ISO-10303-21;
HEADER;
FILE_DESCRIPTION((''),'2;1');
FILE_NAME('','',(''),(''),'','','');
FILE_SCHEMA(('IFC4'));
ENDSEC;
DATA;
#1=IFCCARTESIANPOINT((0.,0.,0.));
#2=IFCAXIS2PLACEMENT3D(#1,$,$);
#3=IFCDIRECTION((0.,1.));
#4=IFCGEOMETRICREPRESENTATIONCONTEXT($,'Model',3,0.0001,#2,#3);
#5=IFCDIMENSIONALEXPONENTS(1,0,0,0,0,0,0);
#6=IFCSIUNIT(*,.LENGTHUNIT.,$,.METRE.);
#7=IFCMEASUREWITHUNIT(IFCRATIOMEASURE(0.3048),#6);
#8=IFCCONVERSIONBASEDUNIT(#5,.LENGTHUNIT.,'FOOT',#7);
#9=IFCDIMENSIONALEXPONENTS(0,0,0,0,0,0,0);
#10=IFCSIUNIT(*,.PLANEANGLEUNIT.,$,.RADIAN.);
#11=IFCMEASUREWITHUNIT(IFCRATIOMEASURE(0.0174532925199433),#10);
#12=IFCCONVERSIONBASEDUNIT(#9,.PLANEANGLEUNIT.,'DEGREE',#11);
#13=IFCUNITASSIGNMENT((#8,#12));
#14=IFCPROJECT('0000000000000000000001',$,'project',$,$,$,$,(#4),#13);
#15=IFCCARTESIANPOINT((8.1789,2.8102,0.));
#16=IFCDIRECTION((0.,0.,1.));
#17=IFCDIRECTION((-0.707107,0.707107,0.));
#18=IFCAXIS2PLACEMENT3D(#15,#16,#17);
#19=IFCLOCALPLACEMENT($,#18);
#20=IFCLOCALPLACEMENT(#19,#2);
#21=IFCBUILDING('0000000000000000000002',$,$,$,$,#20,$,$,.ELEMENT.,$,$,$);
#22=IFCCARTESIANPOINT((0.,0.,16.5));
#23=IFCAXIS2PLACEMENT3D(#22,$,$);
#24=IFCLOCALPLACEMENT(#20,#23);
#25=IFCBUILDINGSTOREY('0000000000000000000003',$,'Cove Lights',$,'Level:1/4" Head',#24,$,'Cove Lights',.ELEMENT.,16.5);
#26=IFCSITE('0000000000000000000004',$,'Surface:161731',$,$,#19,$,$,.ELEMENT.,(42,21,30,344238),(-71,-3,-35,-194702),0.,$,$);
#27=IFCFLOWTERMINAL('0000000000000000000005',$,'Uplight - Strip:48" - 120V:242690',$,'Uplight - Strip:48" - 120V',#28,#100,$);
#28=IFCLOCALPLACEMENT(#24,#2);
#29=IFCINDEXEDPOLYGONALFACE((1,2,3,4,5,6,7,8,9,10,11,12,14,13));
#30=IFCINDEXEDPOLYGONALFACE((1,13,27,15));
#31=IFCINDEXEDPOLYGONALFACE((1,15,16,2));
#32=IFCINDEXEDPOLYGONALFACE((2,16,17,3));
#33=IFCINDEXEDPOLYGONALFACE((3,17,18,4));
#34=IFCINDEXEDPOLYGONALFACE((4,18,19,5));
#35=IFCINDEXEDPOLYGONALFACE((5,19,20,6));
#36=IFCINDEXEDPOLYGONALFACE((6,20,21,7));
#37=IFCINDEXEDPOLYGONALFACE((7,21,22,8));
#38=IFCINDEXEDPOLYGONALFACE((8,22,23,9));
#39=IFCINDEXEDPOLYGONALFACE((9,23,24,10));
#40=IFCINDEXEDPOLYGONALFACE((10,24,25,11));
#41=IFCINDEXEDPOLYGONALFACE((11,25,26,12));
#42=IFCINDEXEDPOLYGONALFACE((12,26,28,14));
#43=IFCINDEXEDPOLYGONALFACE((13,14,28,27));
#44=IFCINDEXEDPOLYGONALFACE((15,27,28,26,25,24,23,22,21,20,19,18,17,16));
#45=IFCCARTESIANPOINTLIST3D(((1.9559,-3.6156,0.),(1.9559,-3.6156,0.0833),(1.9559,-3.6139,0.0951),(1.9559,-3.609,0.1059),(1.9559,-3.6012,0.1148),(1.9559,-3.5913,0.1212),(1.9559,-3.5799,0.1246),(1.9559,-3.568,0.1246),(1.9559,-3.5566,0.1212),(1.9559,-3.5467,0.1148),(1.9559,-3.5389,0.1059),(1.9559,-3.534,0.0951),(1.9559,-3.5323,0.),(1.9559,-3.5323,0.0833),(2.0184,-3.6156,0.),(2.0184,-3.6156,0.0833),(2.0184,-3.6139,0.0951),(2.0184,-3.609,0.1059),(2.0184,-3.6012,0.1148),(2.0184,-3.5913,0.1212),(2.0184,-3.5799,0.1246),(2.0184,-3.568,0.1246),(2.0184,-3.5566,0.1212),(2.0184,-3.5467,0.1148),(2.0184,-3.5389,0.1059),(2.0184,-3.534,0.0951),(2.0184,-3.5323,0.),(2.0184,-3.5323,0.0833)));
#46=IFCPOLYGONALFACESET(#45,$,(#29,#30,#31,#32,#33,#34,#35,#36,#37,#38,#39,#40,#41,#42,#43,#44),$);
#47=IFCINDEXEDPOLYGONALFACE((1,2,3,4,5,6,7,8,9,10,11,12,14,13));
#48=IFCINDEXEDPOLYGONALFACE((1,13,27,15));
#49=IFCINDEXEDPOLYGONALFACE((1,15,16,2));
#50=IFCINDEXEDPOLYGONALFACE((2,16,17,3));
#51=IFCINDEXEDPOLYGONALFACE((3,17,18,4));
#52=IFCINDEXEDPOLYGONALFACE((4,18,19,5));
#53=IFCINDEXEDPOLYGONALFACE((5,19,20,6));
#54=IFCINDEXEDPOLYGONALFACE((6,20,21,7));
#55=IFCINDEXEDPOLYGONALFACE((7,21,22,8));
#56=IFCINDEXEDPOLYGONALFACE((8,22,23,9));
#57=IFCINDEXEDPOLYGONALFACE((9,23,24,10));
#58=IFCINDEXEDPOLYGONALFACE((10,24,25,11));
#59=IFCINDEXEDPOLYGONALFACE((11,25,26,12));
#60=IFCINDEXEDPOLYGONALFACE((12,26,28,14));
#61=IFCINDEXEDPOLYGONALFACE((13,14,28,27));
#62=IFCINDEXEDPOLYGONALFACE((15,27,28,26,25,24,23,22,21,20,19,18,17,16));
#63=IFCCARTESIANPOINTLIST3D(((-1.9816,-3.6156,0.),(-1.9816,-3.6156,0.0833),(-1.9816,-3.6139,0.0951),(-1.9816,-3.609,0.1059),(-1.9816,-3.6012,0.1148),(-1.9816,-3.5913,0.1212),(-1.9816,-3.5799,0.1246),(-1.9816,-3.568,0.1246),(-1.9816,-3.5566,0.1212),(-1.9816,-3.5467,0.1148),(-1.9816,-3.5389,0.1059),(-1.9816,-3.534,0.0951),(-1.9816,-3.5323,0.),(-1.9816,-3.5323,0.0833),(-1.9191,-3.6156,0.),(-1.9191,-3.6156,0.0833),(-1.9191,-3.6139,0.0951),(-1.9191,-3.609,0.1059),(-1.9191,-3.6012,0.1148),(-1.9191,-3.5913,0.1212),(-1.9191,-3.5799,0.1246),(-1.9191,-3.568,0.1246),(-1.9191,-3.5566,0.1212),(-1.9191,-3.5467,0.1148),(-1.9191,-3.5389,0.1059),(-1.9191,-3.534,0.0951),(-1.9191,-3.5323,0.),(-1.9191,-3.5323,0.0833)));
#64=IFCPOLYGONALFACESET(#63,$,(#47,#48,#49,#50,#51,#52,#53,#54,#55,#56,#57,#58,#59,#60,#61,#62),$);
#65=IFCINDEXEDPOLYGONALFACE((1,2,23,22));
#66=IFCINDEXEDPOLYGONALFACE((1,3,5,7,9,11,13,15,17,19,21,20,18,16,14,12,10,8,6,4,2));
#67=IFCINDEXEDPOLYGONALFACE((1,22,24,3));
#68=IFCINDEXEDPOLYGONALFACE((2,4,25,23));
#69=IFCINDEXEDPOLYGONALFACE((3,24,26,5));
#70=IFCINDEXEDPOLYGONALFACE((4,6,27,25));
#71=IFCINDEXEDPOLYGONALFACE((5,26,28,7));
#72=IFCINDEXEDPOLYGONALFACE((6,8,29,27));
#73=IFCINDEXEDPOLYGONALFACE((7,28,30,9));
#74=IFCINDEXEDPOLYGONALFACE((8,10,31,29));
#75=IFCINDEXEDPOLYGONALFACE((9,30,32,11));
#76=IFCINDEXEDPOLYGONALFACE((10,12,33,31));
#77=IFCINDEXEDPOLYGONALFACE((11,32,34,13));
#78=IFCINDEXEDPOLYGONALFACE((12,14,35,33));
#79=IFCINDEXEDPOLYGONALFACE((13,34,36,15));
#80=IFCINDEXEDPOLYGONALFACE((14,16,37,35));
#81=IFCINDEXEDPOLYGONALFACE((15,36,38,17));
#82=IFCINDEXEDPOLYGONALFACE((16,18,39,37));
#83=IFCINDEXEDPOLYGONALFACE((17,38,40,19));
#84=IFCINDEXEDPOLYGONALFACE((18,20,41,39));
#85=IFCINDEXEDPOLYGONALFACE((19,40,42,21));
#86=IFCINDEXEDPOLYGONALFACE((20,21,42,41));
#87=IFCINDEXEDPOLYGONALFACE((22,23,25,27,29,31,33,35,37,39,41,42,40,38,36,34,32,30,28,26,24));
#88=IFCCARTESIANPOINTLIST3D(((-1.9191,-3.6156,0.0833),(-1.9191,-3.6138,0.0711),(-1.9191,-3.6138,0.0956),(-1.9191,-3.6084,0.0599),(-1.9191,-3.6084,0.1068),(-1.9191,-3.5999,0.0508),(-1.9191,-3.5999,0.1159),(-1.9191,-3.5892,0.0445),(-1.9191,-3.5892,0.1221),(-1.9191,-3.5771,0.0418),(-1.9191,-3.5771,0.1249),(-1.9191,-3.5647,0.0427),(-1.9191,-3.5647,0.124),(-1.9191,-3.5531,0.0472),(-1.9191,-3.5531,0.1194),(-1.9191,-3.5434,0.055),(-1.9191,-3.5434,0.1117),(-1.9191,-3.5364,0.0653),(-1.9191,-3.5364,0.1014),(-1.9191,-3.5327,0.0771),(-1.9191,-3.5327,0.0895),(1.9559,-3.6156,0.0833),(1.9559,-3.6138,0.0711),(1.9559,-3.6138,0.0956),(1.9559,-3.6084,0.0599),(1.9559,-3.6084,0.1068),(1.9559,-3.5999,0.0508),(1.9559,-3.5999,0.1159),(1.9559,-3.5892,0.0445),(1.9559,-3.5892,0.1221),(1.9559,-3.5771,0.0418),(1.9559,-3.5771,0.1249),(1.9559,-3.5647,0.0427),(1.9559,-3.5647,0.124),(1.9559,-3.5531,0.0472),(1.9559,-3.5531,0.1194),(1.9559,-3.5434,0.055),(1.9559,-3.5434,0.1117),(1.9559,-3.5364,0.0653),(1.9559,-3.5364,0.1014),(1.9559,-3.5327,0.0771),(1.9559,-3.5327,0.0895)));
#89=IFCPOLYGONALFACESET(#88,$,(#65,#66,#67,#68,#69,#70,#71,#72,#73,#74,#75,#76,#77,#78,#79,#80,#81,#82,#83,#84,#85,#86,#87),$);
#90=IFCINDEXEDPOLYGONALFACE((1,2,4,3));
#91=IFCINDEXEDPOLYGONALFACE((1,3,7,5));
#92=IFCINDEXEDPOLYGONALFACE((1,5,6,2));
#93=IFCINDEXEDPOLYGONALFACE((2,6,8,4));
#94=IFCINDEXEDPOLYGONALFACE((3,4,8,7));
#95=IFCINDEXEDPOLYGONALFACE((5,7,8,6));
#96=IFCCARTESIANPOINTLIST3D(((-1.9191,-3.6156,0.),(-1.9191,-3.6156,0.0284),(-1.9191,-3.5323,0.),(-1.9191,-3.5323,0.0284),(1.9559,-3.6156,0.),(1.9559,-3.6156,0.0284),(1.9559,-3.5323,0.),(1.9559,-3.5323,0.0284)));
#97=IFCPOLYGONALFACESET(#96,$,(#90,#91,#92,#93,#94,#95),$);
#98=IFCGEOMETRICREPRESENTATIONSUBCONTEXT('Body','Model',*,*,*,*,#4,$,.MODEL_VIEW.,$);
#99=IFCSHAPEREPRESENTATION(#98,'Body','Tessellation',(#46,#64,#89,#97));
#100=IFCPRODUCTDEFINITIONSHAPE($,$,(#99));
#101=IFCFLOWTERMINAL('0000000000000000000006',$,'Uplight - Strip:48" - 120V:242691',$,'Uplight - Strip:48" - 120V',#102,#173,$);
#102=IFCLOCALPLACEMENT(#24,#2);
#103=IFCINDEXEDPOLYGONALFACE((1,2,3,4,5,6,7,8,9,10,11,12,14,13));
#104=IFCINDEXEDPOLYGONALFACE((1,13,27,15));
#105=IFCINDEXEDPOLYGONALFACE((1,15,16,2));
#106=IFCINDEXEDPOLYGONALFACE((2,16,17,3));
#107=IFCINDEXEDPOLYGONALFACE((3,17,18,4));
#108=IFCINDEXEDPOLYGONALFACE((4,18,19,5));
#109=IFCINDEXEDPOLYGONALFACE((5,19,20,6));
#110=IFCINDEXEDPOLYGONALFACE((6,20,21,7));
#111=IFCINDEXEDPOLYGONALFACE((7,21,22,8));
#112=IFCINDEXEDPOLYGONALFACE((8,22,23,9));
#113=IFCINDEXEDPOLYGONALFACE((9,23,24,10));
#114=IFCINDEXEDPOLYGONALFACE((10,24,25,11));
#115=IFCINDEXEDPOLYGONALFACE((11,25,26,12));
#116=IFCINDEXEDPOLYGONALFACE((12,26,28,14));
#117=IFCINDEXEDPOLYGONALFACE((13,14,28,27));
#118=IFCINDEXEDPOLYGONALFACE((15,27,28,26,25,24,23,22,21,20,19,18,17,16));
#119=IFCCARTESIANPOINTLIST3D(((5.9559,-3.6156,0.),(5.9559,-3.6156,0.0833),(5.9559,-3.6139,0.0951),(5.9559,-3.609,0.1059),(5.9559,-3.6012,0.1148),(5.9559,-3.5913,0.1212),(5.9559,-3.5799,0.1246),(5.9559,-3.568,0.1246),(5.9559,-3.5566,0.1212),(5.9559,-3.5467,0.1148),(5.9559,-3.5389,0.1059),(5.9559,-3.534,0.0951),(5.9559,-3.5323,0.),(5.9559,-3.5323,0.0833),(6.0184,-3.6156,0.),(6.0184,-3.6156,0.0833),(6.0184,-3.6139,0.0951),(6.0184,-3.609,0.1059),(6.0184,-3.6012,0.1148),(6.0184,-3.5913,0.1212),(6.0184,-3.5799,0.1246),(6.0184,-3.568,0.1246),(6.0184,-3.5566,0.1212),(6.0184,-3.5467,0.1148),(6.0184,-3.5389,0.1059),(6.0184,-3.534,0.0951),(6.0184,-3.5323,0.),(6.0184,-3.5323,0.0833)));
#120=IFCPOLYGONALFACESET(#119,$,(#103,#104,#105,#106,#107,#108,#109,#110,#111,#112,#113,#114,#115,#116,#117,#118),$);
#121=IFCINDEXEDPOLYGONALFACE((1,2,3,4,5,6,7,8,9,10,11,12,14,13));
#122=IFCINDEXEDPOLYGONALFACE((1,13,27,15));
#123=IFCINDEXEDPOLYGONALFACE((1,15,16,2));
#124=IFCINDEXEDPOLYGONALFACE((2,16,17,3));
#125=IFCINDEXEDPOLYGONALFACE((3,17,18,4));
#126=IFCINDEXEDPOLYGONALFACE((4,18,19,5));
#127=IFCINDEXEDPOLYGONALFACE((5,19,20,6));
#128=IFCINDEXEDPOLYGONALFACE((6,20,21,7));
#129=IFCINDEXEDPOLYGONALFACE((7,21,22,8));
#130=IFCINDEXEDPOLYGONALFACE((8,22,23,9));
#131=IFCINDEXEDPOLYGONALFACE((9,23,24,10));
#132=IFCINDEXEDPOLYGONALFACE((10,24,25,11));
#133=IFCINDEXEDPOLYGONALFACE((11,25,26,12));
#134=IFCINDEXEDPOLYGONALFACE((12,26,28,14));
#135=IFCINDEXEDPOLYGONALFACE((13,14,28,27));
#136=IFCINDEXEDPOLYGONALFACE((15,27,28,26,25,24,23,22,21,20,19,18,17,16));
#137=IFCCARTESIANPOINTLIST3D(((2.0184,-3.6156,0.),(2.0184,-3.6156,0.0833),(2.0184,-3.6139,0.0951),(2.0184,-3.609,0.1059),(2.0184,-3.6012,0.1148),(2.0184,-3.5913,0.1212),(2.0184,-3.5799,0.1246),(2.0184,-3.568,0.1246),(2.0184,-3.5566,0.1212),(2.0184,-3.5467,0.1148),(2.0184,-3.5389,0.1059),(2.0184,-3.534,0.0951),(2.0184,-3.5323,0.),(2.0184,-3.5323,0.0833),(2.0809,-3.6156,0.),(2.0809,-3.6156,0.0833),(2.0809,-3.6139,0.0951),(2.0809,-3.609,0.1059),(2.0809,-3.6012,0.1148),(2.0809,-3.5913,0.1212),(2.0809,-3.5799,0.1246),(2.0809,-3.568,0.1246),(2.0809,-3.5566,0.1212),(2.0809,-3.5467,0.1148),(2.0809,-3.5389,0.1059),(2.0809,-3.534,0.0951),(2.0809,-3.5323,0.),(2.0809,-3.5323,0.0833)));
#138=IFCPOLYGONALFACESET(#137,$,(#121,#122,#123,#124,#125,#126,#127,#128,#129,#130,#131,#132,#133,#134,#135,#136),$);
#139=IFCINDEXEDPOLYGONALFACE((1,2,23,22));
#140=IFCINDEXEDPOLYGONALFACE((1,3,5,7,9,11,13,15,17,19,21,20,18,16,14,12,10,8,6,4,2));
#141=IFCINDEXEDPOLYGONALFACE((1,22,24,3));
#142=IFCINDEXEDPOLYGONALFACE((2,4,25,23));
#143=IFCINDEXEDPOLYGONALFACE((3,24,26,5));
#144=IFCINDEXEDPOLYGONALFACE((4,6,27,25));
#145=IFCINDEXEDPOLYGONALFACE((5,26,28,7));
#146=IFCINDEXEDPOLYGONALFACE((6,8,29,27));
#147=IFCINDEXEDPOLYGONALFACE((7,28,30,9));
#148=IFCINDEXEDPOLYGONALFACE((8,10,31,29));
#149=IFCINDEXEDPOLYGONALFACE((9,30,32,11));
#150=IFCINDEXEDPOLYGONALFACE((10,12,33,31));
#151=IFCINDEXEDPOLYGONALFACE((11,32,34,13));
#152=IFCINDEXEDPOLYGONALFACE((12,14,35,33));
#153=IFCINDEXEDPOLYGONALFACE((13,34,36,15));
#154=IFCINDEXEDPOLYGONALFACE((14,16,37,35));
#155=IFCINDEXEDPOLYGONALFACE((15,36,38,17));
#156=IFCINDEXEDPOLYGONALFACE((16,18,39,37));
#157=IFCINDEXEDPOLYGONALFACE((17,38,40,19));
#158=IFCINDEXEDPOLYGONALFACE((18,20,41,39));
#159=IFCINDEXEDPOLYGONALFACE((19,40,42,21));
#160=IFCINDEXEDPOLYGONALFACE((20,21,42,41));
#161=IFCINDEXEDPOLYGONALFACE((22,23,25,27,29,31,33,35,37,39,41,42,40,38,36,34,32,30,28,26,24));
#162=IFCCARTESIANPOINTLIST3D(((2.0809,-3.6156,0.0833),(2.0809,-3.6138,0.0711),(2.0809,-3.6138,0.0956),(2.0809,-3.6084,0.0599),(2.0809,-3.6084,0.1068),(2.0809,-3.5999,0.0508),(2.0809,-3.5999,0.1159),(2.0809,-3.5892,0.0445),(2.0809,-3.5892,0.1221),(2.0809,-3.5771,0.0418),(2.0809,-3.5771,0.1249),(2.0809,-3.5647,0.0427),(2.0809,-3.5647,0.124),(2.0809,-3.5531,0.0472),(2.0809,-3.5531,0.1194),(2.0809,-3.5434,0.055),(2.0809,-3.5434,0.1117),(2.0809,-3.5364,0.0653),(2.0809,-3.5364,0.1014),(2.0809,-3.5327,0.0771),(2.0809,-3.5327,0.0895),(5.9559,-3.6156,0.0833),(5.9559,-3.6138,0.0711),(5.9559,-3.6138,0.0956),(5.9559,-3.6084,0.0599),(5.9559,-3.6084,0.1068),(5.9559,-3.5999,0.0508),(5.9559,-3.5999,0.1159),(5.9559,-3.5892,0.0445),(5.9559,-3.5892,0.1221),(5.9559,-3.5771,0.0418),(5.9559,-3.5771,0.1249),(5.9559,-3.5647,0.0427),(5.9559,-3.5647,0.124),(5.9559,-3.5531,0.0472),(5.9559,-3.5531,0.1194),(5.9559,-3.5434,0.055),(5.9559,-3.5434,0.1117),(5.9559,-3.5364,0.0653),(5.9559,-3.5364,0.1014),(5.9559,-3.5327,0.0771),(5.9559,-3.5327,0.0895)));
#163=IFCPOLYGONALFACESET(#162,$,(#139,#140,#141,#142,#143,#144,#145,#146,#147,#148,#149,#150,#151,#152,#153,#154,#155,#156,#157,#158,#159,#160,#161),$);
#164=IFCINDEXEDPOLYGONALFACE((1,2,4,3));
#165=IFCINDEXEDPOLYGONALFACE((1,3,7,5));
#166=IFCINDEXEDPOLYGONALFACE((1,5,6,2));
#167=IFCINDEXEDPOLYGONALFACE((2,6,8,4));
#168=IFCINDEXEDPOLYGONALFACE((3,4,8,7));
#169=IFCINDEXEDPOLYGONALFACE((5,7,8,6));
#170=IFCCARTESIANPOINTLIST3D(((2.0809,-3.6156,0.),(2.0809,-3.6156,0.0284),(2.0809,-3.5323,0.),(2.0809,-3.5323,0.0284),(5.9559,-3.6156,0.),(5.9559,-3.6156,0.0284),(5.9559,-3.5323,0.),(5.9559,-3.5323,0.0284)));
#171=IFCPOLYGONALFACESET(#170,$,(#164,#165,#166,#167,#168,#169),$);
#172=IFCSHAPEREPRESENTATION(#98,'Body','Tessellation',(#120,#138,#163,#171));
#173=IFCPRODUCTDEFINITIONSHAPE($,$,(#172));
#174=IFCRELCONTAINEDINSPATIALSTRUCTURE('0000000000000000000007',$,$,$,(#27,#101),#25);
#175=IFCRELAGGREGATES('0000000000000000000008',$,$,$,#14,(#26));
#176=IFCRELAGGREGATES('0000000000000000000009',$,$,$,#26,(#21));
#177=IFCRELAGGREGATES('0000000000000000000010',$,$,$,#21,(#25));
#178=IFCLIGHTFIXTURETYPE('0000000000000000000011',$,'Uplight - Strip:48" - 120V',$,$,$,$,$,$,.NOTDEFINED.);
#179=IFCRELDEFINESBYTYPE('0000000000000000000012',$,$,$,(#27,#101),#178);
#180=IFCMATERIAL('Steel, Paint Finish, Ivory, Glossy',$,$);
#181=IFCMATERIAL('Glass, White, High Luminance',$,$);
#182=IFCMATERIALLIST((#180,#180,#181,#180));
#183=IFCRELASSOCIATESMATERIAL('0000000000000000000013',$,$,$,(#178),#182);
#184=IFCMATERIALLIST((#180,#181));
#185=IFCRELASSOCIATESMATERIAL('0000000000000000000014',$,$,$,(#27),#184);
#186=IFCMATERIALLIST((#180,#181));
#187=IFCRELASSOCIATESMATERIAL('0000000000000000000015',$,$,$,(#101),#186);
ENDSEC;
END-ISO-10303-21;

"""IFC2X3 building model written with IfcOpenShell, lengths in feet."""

from ifc_helpers import new_model, entity, si_unit, converted_unit, direction, frame, frame_2d, origin, origin_2d_with_axis, place, context, subcontext, project, spatial, polyline, circle_curve, parameter, trimmed, segment, composite_curve, rectangle, circle, outline, extrude, source, transform, mapped, material, material_list, type_object, type_shapes, element, save


model = new_model("IFC2X3")

# Units and contexts
model_context = context("Model", 3, precision=0.0001, world=origin(), true_north=direction((0.0, 1.0)))
body_context = subcontext(model_context, "Body", "Model", "MODEL_VIEW")
ifc_project = project(units=[converted_unit("LENGTHUNIT", "FOOT", entity("IfcRatioMeasure", 0.3048), si_unit("LENGTHUNIT", "METRE"), dimensions=[1, 0, 0, 0, 0, 0, 0]), converted_unit("PLANEANGLEUNIT", "DEGREE", entity("IfcRatioMeasure", 0.0174532925199433), si_unit("PLANEANGLEUNIT", "RADIAN"), dimensions=[0, 0, 0, 0, 0, 0, 0])], contexts=[model_context])

# Site, building, storey
site_placement = place(None, frame((8.1789, 2.8102, 0.0), z_axis=(0.0, 0.0, 1.0), x_axis=(-0.707107, 0.707107, 0.0)))
site = spatial("IfcSite", under=ifc_project, at=site_placement, Name="Surface:161731", CompositionType="ELEMENT", RefLatitude=(42, 21, 30, 344238), RefLongitude=(-71, -3, -35, -194702), RefElevation=0.0)
building_placement = place(site_placement, origin())
building = spatial("IfcBuilding", under=site, at=building_placement, CompositionType="ELEMENT")
storey_placement = place(building_placement, frame((0.0, 0.0, 16.5)))
storey = spatial("IfcBuildingStorey", under=building, at=storey_placement, Name="Cove Lights", ObjectType="Level:1/4\" Head", LongName="Cove Lights", CompositionType="ELEMENT", Elevation=16.5)

# Flow terminals
ifc_material_1 = material(Name="Steel, Paint Finish, Ivory, Glossy")
ifc_material_2 = material(Name="Glass, White, High Luminance")
ifc_material_list_1 = material_list([ifc_material_1, ifc_material_1, ifc_material_2, ifc_material_1])
light_fixture_type_1 = type_object("IfcLightFixtureType", Name="Uplight - Strip:48\" - 120V", PredefinedType="NOTDEFINED", material=ifc_material_list_1)
shared_shape_1 = source(origin(), body_context, "Body", "SweptSolid", [
    extrude(outline(composite_curve([segment(polyline([(-0.0417, -0.0417), (0.0417, -0.0417)]), True, "CONTINUOUS"), segment(polyline([(0.0417, -0.0417), (0.0417, 0.0417)]), True, "CONTINUOUS"), segment(trimmed(circle_curve(frame_2d((0.0, 0.0417), x_axis=(-1.0, 0.0)), 0.0417), [parameter(180.0)], [parameter(0.0)], True, "PARAMETER"), True, "CONTINUOUS"), segment(polyline([(-0.0417, 0.0417), (-0.0417, -0.0417)]), True, "CONTINUOUS")], self_intersect=False)), frame((1.9375, 0.0, 0.0417), z_axis=(1.0, 0.0, 0.0), x_axis=(0.0, 1.0, 0.0)), (0.0, 0.0, 1.0), 0.0625),
    extrude(outline(composite_curve([segment(polyline([(-0.0417, -0.0417), (0.0417, -0.0417)]), True, "CONTINUOUS"), segment(trimmed(circle_curve(frame_2d((0.0417, 0.0), x_axis=(1.0, 0.0)), 0.0417), [parameter(270.0)], [parameter(90.0)], True, "PARAMETER"), True, "CONTINUOUS"), segment(polyline([(0.0417, 0.0417), (-0.0417, 0.0417)]), True, "CONTINUOUS"), segment(polyline([(-0.0417, 0.0417), (-0.0417, -0.0417)]), True, "CONTINUOUS")], self_intersect=False)), frame((-2.0, 0.0, 0.0417), z_axis=(1.0, 0.0, 0.0), x_axis=(0.0, 0.0, 1.0)), (0.0, 0.0, 1.0), 0.0625),
    extrude(circle(Radius=0.0417, at=frame_2d((0.0, 0.0), x_axis=(1.0, 0.0))), frame((-1.9375, 0.0, 0.0833), z_axis=(1.0, 0.0, 0.0), x_axis=(0.0, -1.0, 0.0)), (0.0, 0.0, 1.0), 3.875),
    extrude(rectangle(XDim=0.0833, YDim=3.875, at=origin_2d_with_axis()), frame((0.0, 0.0, 0.0), z_axis=(0.0, 0.0, 1.0), x_axis=(0.0, 1.0, 0.0)), (0.0, 0.0, 1.0), 0.0284),
])
type_shapes(light_fixture_type_1, [shared_shape_1])
ifc_material_list_2 = material_list([ifc_material_1, ifc_material_2])
flow_terminal_1_placement = place(storey_placement, frame((0.0184, -3.5739, 0.0)))
element("IfcFlowTerminal", 1, at=flow_terminal_1_placement, inside=storey, type_object=light_fixture_type_1, material=ifc_material_list_2, Name="Uplight - Strip:48\" - 120V:242690", ObjectType="Uplight - Strip:48\" - 120V", context=body_context, shape_type="MappedRepresentation", body=[
    mapped(shared_shape_1, transform((0.0, 0.0, 0.0), scale=1.0)),
])
ifc_material_list_3 = material_list([ifc_material_1, ifc_material_2])
flow_terminal_2_placement = place(storey_placement, frame((4.0184, -3.5739, 0.0)))
element("IfcFlowTerminal", 2, at=flow_terminal_2_placement, inside=storey, type_object=light_fixture_type_1, material=ifc_material_list_3, Name="Uplight - Strip:48\" - 120V:242691", ObjectType="Uplight - Strip:48\" - 120V", context=body_context, shape_type="MappedRepresentation", body=[
    mapped(shared_shape_1, transform((0.0, 0.0, 0.0), scale=1.0)),
])

save(model, "model.ifc")
